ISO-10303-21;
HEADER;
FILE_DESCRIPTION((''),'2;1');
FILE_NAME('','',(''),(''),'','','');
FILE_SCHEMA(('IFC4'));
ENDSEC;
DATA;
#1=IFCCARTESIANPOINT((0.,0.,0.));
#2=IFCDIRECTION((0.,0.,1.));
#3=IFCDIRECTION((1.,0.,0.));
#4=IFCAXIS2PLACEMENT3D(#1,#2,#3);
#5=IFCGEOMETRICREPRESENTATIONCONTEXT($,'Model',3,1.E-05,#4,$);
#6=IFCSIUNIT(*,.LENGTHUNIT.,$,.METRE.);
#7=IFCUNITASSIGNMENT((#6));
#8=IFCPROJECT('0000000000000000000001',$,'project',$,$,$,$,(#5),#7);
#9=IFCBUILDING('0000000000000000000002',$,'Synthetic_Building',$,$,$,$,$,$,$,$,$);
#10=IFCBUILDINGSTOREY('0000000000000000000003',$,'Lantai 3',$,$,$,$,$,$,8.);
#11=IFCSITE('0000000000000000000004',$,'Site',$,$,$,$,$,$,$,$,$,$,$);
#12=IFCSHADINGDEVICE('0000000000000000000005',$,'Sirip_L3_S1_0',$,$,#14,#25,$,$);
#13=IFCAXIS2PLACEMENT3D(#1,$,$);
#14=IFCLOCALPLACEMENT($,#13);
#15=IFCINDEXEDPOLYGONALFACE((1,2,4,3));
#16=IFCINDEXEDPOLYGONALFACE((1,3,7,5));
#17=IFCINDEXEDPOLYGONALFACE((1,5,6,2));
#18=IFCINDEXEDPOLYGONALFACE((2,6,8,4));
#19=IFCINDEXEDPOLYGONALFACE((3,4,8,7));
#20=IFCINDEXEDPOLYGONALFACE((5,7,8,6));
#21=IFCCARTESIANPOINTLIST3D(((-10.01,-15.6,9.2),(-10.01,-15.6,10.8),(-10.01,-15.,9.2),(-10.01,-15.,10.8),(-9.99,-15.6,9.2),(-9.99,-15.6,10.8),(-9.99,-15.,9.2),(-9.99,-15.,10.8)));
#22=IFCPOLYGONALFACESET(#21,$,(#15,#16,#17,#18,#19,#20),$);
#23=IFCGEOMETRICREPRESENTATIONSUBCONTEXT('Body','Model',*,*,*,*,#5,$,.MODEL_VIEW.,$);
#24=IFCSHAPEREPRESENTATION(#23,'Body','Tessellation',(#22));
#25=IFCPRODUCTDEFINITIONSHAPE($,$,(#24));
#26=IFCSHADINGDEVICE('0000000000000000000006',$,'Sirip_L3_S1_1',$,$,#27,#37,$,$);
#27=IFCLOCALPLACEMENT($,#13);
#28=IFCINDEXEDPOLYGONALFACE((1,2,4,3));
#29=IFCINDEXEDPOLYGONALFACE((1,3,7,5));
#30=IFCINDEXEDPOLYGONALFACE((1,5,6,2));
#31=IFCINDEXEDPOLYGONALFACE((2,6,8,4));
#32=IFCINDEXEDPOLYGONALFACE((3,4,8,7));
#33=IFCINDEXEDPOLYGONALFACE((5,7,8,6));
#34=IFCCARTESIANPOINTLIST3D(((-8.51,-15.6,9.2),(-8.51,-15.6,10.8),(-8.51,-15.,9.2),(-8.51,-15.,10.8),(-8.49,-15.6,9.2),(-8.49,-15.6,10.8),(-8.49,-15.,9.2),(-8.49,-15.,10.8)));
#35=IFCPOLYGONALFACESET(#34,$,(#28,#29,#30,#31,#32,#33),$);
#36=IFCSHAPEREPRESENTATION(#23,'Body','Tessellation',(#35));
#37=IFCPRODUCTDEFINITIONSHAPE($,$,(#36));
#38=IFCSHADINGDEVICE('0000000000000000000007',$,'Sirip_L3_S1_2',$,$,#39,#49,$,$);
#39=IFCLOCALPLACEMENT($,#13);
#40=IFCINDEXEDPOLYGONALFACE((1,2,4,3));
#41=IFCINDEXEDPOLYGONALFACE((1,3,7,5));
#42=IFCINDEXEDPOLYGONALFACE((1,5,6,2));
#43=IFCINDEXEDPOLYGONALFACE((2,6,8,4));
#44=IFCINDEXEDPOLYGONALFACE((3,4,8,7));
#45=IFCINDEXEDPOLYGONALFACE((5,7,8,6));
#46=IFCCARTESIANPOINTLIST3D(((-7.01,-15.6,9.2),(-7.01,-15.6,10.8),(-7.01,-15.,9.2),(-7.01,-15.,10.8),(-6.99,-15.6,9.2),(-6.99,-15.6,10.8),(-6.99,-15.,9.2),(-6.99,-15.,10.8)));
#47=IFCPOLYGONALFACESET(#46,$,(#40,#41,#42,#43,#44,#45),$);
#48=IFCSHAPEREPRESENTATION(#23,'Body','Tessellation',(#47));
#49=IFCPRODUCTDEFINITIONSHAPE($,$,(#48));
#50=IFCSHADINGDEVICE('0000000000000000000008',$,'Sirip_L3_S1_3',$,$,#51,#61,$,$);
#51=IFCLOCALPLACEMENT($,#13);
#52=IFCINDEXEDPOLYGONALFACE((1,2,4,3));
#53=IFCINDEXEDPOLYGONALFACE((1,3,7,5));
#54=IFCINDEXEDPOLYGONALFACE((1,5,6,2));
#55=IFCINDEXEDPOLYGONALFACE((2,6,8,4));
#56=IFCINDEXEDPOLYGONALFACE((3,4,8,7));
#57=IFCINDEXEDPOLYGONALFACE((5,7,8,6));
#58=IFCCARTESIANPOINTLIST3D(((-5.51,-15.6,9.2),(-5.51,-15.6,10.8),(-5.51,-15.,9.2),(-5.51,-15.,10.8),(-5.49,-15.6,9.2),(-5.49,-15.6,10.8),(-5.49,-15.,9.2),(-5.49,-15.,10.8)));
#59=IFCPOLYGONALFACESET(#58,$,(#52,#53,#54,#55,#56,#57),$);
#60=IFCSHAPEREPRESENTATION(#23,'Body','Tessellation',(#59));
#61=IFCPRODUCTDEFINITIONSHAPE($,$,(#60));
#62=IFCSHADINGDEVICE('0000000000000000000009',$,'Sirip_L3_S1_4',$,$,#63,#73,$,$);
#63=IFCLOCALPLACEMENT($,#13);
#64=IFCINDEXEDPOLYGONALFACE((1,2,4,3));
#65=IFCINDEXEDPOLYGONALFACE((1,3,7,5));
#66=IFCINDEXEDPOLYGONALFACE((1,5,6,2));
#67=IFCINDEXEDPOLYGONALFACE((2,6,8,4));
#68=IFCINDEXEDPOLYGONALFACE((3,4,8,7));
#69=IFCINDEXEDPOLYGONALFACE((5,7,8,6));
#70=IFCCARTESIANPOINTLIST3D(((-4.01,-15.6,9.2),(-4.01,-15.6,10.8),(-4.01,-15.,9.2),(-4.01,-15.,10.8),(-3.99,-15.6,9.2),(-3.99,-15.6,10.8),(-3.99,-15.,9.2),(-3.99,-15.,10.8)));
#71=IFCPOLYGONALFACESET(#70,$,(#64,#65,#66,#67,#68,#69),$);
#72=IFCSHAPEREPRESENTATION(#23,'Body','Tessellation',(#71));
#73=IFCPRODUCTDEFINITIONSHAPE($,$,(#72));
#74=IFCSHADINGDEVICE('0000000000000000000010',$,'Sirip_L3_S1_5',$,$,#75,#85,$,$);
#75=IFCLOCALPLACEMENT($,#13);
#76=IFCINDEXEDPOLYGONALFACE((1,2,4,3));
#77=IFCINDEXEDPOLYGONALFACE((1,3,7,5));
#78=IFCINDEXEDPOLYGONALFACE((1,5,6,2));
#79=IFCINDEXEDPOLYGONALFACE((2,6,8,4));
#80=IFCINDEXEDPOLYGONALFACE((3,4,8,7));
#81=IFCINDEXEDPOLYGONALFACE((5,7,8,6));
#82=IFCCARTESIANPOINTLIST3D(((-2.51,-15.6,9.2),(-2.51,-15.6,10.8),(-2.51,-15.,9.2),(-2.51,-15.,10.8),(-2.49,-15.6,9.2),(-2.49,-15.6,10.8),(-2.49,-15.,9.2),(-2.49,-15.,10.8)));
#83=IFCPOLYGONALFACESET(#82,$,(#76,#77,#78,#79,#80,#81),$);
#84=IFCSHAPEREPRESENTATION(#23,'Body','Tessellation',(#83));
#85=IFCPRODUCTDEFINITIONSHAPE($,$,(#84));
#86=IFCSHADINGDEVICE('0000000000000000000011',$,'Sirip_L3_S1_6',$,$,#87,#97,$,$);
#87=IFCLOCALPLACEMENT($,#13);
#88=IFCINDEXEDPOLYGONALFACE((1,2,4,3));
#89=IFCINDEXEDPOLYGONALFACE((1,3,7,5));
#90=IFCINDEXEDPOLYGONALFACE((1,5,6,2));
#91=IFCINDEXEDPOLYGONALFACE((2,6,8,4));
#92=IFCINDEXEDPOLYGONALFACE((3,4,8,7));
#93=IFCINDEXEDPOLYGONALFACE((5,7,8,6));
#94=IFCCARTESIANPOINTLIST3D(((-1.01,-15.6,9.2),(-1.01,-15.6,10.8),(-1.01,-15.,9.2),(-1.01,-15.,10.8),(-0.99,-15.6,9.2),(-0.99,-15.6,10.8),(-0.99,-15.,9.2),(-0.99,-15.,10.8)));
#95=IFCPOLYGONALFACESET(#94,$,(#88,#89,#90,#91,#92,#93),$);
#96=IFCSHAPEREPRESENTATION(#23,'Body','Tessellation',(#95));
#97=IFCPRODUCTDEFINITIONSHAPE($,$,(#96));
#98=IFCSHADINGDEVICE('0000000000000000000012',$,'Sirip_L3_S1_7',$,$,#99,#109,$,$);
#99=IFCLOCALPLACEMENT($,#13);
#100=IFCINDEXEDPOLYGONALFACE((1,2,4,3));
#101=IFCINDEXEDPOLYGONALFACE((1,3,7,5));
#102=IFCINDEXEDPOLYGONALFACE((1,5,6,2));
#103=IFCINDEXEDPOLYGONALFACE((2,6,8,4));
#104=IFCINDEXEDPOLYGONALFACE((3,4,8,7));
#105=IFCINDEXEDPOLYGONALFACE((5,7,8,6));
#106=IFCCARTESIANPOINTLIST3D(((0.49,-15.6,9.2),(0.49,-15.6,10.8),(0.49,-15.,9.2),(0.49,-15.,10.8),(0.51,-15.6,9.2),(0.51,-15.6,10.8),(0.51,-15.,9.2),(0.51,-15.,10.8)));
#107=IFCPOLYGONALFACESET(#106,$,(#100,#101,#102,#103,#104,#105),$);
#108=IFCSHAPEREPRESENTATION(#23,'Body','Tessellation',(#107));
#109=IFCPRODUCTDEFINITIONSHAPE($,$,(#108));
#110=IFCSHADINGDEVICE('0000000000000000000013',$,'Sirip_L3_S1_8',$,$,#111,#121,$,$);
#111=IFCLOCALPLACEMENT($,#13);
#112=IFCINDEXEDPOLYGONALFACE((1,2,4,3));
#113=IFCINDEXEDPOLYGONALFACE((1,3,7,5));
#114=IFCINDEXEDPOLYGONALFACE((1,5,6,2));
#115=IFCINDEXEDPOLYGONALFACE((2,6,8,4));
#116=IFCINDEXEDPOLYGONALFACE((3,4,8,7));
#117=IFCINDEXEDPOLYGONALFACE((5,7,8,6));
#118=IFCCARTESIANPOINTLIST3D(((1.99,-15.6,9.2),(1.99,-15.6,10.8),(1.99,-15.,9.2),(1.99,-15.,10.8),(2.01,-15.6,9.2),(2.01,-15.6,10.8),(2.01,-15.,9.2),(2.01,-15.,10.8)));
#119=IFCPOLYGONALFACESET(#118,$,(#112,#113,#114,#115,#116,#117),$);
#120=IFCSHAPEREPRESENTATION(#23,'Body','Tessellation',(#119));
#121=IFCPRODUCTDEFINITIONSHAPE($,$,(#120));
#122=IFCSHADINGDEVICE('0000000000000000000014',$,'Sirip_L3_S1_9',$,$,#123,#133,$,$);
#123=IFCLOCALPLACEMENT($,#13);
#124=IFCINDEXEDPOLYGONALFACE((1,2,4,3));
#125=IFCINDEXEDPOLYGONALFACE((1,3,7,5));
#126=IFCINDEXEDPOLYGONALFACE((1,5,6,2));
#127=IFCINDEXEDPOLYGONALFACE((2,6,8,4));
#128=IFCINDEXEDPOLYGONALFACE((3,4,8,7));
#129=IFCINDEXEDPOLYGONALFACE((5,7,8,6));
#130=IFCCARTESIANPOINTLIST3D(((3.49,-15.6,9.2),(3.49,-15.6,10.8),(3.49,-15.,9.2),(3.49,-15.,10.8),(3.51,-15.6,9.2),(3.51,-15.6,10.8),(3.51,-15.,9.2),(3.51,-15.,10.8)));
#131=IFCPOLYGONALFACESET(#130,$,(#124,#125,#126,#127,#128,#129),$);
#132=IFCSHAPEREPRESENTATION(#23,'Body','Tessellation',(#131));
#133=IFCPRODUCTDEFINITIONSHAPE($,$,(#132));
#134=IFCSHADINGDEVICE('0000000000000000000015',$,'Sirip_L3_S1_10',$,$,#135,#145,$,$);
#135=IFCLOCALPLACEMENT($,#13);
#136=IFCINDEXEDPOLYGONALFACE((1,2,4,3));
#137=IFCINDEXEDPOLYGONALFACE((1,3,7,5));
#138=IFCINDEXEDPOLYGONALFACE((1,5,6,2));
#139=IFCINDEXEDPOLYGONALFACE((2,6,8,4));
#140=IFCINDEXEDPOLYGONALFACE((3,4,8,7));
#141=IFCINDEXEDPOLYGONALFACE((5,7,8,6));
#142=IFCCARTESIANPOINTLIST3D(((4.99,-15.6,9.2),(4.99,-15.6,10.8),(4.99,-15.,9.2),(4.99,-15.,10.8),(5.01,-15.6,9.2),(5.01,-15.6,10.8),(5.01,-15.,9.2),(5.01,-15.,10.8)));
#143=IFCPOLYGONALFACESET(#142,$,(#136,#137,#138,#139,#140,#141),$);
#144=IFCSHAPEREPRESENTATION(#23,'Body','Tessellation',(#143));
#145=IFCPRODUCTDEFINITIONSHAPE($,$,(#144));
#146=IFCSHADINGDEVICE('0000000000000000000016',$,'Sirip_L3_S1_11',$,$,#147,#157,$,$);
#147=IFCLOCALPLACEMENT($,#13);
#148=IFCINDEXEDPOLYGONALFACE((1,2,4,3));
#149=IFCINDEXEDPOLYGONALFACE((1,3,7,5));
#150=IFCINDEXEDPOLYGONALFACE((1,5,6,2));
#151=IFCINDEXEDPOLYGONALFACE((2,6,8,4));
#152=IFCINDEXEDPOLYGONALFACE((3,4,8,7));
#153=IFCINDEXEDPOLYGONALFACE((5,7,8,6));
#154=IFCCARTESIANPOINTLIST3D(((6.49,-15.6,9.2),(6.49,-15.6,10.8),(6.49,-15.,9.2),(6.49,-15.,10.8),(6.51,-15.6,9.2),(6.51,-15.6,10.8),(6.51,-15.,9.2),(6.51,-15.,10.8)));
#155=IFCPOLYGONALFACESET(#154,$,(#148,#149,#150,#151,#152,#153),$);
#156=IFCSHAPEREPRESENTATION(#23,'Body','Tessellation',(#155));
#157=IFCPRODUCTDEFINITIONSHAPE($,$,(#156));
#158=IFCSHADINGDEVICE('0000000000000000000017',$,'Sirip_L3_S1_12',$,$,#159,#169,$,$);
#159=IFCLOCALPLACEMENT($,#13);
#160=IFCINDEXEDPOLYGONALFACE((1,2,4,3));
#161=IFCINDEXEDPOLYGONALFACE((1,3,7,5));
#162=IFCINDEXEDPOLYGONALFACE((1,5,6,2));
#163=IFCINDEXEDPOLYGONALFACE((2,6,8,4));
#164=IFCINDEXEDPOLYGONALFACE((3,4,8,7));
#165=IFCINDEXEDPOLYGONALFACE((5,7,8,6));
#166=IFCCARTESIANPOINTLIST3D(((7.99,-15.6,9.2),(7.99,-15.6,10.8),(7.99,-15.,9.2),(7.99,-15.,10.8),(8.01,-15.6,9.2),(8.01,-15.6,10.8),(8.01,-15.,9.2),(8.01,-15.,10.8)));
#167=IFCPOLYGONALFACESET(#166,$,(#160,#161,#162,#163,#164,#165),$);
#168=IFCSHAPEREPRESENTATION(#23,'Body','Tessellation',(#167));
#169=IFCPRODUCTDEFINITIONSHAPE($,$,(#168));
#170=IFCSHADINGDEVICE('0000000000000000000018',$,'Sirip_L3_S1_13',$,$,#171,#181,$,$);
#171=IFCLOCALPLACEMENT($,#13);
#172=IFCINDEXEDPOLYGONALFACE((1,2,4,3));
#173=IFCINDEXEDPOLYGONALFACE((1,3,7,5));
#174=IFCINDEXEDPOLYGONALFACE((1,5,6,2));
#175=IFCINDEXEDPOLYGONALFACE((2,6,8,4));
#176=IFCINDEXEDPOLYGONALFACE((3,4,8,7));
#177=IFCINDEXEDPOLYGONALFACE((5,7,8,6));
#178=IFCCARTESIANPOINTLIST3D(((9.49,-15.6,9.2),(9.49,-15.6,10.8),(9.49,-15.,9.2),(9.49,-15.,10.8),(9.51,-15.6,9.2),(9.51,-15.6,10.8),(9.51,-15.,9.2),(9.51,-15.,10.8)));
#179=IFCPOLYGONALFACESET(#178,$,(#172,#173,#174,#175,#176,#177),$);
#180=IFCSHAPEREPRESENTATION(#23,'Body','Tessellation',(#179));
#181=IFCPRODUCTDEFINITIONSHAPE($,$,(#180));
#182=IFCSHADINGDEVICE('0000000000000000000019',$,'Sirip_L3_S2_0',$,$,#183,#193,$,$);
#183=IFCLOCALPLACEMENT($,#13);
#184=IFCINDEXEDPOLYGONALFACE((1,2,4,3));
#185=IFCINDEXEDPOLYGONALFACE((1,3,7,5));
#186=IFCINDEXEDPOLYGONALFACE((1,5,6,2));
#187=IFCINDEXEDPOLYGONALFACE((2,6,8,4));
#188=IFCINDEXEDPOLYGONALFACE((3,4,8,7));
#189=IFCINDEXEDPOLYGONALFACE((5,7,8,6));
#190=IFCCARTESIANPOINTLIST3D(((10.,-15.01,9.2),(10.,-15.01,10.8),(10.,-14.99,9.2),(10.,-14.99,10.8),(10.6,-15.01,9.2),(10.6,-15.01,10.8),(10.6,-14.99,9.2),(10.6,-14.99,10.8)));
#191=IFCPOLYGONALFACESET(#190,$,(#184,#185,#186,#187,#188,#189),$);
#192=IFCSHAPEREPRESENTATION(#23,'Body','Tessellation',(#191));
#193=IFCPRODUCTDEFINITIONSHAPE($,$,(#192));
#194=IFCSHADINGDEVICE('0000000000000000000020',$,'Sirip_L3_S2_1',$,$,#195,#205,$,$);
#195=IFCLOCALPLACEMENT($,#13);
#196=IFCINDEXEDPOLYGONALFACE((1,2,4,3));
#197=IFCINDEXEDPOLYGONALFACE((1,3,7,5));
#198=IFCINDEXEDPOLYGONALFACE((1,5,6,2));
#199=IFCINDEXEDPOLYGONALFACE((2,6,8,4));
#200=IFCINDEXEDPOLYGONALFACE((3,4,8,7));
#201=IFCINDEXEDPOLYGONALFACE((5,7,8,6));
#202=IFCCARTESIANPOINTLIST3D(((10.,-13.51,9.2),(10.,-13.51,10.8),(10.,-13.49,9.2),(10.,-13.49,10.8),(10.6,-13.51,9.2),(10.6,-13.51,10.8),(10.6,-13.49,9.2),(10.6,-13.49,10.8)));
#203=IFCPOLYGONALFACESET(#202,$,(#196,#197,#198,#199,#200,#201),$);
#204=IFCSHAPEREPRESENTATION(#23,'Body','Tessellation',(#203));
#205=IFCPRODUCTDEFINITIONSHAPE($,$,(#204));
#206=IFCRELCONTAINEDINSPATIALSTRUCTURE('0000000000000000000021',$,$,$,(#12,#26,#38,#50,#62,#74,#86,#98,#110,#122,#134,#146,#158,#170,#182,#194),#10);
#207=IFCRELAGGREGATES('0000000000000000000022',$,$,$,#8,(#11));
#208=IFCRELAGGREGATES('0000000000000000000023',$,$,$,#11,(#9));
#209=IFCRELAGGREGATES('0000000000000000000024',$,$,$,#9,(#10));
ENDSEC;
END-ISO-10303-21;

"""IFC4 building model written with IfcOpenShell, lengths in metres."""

from ifc_helpers import new_model, si_unit, frame, origin_with_axes, place, context, subcontext, project, spatial, polyline, outline, extrude, element, save


model = new_model("IFC4")

# Units and contexts
model_context = context("Model", 3, precision=1e-05, world=origin_with_axes())
body_context = subcontext(model_context, "Body", "Model", "MODEL_VIEW")
ifc_project = project(units=[si_unit("LENGTHUNIT", "METRE")], contexts=[model_context])

# Site, building, storey
site = spatial("IfcSite", under=ifc_project, Name="Site")
building = spatial("IfcBuilding", under=site, Name="Synthetic_Building")
storey = spatial("IfcBuildingStorey", under=building, Name="Lantai 3", Elevation=8.0)

# Shading devices
shading_device_1_placement = place(None, origin_with_axes())
element("IfcShadingDevice", 1, at=shading_device_1_placement, inside=storey, Name="Sirip_L3_S1_0", context=body_context, shape_type="SweptSolid", body=[
    extrude(outline(polyline([(-10.01, -15.0), (-9.99, -15.0), (-9.99, -15.6), (-10.01, -15.6), (-10.01, -15.0)])), frame((0.0, 0.0, 9.2), z_axis=(0.0, 0.0, 1.0), x_axis=(1.0, 0.0, 0.0)), (0.0, 0.0, 1.0), 1.6),
])
shading_device_2_placement = place(None, origin_with_axes())
element("IfcShadingDevice", 2, at=shading_device_2_placement, inside=storey, Name="Sirip_L3_S1_1", context=body_context, shape_type="SweptSolid", body=[
    extrude(outline(polyline([(-8.51, -15.0), (-8.49, -15.0), (-8.49, -15.6), (-8.51, -15.6), (-8.51, -15.0)])), frame((0.0, 0.0, 9.2), z_axis=(0.0, 0.0, 1.0), x_axis=(1.0, 0.0, 0.0)), (0.0, 0.0, 1.0), 1.6),
])
shading_device_3_placement = place(None, origin_with_axes())
element("IfcShadingDevice", 3, at=shading_device_3_placement, inside=storey, Name="Sirip_L3_S1_2", context=body_context, shape_type="SweptSolid", body=[
    extrude(outline(polyline([(-7.01, -15.0), (-6.99, -15.0), (-6.99, -15.6), (-7.01, -15.6), (-7.01, -15.0)])), frame((0.0, 0.0, 9.2), z_axis=(0.0, 0.0, 1.0), x_axis=(1.0, 0.0, 0.0)), (0.0, 0.0, 1.0), 1.6),
])
shading_device_4_placement = place(None, origin_with_axes())
element("IfcShadingDevice", 4, at=shading_device_4_placement, inside=storey, Name="Sirip_L3_S1_3", context=body_context, shape_type="SweptSolid", body=[
    extrude(outline(polyline([(-5.51, -15.0), (-5.49, -15.0), (-5.49, -15.6), (-5.51, -15.6), (-5.51, -15.0)])), frame((0.0, 0.0, 9.2), z_axis=(0.0, 0.0, 1.0), x_axis=(1.0, 0.0, 0.0)), (0.0, 0.0, 1.0), 1.6),
])
shading_device_5_placement = place(None, origin_with_axes())
element("IfcShadingDevice", 5, at=shading_device_5_placement, inside=storey, Name="Sirip_L3_S1_4", context=body_context, shape_type="SweptSolid", body=[
    extrude(outline(polyline([(-4.01, -15.0), (-3.99, -15.0), (-3.99, -15.6), (-4.01, -15.6), (-4.01, -15.0)])), frame((0.0, 0.0, 9.2), z_axis=(0.0, 0.0, 1.0), x_axis=(1.0, 0.0, 0.0)), (0.0, 0.0, 1.0), 1.6),
])
shading_device_6_placement = place(None, origin_with_axes())
element("IfcShadingDevice", 6, at=shading_device_6_placement, inside=storey, Name="Sirip_L3_S1_5", context=body_context, shape_type="SweptSolid", body=[
    extrude(outline(polyline([(-2.51, -15.0), (-2.49, -15.0), (-2.49, -15.6), (-2.51, -15.6), (-2.51, -15.0)])), frame((0.0, 0.0, 9.2), z_axis=(0.0, 0.0, 1.0), x_axis=(1.0, 0.0, 0.0)), (0.0, 0.0, 1.0), 1.6),
])
shading_device_7_placement = place(None, origin_with_axes())
element("IfcShadingDevice", 7, at=shading_device_7_placement, inside=storey, Name="Sirip_L3_S1_6", context=body_context, shape_type="SweptSolid", body=[
    extrude(outline(polyline([(-1.01, -15.0), (-0.99, -15.0), (-0.99, -15.6), (-1.01, -15.6), (-1.01, -15.0)])), frame((0.0, 0.0, 9.2), z_axis=(0.0, 0.0, 1.0), x_axis=(1.0, 0.0, 0.0)), (0.0, 0.0, 1.0), 1.6),
])
shading_device_8_placement = place(None, origin_with_axes())
element("IfcShadingDevice", 8, at=shading_device_8_placement, inside=storey, Name="Sirip_L3_S1_7", context=body_context, shape_type="SweptSolid", body=[
    extrude(outline(polyline([(0.49, -15.0), (0.51, -15.0), (0.51, -15.6), (0.49, -15.6), (0.49, -15.0)])), frame((0.0, 0.0, 9.2), z_axis=(0.0, 0.0, 1.0), x_axis=(1.0, 0.0, 0.0)), (0.0, 0.0, 1.0), 1.6),
])
shading_device_9_placement = place(None, origin_with_axes())
element("IfcShadingDevice", 9, at=shading_device_9_placement, inside=storey, Name="Sirip_L3_S1_8", context=body_context, shape_type="SweptSolid", body=[
    extrude(outline(polyline([(1.99, -15.0), (2.01, -15.0), (2.01, -15.6), (1.99, -15.6), (1.99, -15.0)])), frame((0.0, 0.0, 9.2), z_axis=(0.0, 0.0, 1.0), x_axis=(1.0, 0.0, 0.0)), (0.0, 0.0, 1.0), 1.6),
])
shading_device_10_placement = place(None, origin_with_axes())
element("IfcShadingDevice", 10, at=shading_device_10_placement, inside=storey, Name="Sirip_L3_S1_9", context=body_context, shape_type="SweptSolid", body=[
    extrude(outline(polyline([(3.49, -15.0), (3.51, -15.0), (3.51, -15.6), (3.49, -15.6), (3.49, -15.0)])), frame((0.0, 0.0, 9.2), z_axis=(0.0, 0.0, 1.0), x_axis=(1.0, 0.0, 0.0)), (0.0, 0.0, 1.0), 1.6),
])
shading_device_11_placement = place(None, origin_with_axes())
element("IfcShadingDevice", 11, at=shading_device_11_placement, inside=storey, Name="Sirip_L3_S1_10", context=body_context, shape_type="SweptSolid", body=[
    extrude(outline(polyline([(4.99, -15.0), (5.01, -15.0), (5.01, -15.6), (4.99, -15.6), (4.99, -15.0)])), frame((0.0, 0.0, 9.2), z_axis=(0.0, 0.0, 1.0), x_axis=(1.0, 0.0, 0.0)), (0.0, 0.0, 1.0), 1.6),
])
shading_device_12_placement = place(None, origin_with_axes())
element("IfcShadingDevice", 12, at=shading_device_12_placement, inside=storey, Name="Sirip_L3_S1_11", context=body_context, shape_type="SweptSolid", body=[
    extrude(outline(polyline([(6.49, -15.0), (6.51, -15.0), (6.51, -15.6), (6.49, -15.6), (6.49, -15.0)])), frame((0.0, 0.0, 9.2), z_axis=(0.0, 0.0, 1.0), x_axis=(1.0, 0.0, 0.0)), (0.0, 0.0, 1.0), 1.6),
])
shading_device_13_placement = place(None, origin_with_axes())
element("IfcShadingDevice", 13, at=shading_device_13_placement, inside=storey, Name="Sirip_L3_S1_12", context=body_context, shape_type="SweptSolid", body=[
    extrude(outline(polyline([(7.99, -15.0), (8.01, -15.0), (8.01, -15.6), (7.99, -15.6), (7.99, -15.0)])), frame((0.0, 0.0, 9.2), z_axis=(0.0, 0.0, 1.0), x_axis=(1.0, 0.0, 0.0)), (0.0, 0.0, 1.0), 1.6),
])
shading_device_14_placement = place(None, origin_with_axes())
element("IfcShadingDevice", 14, at=shading_device_14_placement, inside=storey, Name="Sirip_L3_S1_13", context=body_context, shape_type="SweptSolid", body=[
    extrude(outline(polyline([(9.49, -15.0), (9.51, -15.0), (9.51, -15.6), (9.49, -15.6), (9.49, -15.0)])), frame((0.0, 0.0, 9.2), z_axis=(0.0, 0.0, 1.0), x_axis=(1.0, 0.0, 0.0)), (0.0, 0.0, 1.0), 1.6),
])
shading_device_15_placement = place(None, origin_with_axes())
element("IfcShadingDevice", 15, at=shading_device_15_placement, inside=storey, Name="Sirip_L3_S2_0", context=body_context, shape_type="SweptSolid", body=[
    extrude(outline(polyline([(10.0, -15.01), (10.0, -14.99), (10.6, -14.99), (10.6, -15.01), (10.0, -15.01)])), frame((0.0, 0.0, 9.2), z_axis=(0.0, 0.0, 1.0), x_axis=(1.0, 0.0, 0.0)), (0.0, 0.0, 1.0), 1.6),
])
shading_device_16_placement = place(None, origin_with_axes())
element("IfcShadingDevice", 16, at=shading_device_16_placement, inside=storey, Name="Sirip_L3_S2_1", context=body_context, shape_type="SweptSolid", body=[
    extrude(outline(polyline([(10.0, -13.51), (10.0, -13.49), (10.6, -13.49), (10.6, -13.51), (10.0, -13.51)])), frame((0.0, 0.0, 9.2), z_axis=(0.0, 0.0, 1.0), x_axis=(1.0, 0.0, 0.0)), (0.0, 0.0, 1.0), 1.6),
])

save(model, "model.ifc")
